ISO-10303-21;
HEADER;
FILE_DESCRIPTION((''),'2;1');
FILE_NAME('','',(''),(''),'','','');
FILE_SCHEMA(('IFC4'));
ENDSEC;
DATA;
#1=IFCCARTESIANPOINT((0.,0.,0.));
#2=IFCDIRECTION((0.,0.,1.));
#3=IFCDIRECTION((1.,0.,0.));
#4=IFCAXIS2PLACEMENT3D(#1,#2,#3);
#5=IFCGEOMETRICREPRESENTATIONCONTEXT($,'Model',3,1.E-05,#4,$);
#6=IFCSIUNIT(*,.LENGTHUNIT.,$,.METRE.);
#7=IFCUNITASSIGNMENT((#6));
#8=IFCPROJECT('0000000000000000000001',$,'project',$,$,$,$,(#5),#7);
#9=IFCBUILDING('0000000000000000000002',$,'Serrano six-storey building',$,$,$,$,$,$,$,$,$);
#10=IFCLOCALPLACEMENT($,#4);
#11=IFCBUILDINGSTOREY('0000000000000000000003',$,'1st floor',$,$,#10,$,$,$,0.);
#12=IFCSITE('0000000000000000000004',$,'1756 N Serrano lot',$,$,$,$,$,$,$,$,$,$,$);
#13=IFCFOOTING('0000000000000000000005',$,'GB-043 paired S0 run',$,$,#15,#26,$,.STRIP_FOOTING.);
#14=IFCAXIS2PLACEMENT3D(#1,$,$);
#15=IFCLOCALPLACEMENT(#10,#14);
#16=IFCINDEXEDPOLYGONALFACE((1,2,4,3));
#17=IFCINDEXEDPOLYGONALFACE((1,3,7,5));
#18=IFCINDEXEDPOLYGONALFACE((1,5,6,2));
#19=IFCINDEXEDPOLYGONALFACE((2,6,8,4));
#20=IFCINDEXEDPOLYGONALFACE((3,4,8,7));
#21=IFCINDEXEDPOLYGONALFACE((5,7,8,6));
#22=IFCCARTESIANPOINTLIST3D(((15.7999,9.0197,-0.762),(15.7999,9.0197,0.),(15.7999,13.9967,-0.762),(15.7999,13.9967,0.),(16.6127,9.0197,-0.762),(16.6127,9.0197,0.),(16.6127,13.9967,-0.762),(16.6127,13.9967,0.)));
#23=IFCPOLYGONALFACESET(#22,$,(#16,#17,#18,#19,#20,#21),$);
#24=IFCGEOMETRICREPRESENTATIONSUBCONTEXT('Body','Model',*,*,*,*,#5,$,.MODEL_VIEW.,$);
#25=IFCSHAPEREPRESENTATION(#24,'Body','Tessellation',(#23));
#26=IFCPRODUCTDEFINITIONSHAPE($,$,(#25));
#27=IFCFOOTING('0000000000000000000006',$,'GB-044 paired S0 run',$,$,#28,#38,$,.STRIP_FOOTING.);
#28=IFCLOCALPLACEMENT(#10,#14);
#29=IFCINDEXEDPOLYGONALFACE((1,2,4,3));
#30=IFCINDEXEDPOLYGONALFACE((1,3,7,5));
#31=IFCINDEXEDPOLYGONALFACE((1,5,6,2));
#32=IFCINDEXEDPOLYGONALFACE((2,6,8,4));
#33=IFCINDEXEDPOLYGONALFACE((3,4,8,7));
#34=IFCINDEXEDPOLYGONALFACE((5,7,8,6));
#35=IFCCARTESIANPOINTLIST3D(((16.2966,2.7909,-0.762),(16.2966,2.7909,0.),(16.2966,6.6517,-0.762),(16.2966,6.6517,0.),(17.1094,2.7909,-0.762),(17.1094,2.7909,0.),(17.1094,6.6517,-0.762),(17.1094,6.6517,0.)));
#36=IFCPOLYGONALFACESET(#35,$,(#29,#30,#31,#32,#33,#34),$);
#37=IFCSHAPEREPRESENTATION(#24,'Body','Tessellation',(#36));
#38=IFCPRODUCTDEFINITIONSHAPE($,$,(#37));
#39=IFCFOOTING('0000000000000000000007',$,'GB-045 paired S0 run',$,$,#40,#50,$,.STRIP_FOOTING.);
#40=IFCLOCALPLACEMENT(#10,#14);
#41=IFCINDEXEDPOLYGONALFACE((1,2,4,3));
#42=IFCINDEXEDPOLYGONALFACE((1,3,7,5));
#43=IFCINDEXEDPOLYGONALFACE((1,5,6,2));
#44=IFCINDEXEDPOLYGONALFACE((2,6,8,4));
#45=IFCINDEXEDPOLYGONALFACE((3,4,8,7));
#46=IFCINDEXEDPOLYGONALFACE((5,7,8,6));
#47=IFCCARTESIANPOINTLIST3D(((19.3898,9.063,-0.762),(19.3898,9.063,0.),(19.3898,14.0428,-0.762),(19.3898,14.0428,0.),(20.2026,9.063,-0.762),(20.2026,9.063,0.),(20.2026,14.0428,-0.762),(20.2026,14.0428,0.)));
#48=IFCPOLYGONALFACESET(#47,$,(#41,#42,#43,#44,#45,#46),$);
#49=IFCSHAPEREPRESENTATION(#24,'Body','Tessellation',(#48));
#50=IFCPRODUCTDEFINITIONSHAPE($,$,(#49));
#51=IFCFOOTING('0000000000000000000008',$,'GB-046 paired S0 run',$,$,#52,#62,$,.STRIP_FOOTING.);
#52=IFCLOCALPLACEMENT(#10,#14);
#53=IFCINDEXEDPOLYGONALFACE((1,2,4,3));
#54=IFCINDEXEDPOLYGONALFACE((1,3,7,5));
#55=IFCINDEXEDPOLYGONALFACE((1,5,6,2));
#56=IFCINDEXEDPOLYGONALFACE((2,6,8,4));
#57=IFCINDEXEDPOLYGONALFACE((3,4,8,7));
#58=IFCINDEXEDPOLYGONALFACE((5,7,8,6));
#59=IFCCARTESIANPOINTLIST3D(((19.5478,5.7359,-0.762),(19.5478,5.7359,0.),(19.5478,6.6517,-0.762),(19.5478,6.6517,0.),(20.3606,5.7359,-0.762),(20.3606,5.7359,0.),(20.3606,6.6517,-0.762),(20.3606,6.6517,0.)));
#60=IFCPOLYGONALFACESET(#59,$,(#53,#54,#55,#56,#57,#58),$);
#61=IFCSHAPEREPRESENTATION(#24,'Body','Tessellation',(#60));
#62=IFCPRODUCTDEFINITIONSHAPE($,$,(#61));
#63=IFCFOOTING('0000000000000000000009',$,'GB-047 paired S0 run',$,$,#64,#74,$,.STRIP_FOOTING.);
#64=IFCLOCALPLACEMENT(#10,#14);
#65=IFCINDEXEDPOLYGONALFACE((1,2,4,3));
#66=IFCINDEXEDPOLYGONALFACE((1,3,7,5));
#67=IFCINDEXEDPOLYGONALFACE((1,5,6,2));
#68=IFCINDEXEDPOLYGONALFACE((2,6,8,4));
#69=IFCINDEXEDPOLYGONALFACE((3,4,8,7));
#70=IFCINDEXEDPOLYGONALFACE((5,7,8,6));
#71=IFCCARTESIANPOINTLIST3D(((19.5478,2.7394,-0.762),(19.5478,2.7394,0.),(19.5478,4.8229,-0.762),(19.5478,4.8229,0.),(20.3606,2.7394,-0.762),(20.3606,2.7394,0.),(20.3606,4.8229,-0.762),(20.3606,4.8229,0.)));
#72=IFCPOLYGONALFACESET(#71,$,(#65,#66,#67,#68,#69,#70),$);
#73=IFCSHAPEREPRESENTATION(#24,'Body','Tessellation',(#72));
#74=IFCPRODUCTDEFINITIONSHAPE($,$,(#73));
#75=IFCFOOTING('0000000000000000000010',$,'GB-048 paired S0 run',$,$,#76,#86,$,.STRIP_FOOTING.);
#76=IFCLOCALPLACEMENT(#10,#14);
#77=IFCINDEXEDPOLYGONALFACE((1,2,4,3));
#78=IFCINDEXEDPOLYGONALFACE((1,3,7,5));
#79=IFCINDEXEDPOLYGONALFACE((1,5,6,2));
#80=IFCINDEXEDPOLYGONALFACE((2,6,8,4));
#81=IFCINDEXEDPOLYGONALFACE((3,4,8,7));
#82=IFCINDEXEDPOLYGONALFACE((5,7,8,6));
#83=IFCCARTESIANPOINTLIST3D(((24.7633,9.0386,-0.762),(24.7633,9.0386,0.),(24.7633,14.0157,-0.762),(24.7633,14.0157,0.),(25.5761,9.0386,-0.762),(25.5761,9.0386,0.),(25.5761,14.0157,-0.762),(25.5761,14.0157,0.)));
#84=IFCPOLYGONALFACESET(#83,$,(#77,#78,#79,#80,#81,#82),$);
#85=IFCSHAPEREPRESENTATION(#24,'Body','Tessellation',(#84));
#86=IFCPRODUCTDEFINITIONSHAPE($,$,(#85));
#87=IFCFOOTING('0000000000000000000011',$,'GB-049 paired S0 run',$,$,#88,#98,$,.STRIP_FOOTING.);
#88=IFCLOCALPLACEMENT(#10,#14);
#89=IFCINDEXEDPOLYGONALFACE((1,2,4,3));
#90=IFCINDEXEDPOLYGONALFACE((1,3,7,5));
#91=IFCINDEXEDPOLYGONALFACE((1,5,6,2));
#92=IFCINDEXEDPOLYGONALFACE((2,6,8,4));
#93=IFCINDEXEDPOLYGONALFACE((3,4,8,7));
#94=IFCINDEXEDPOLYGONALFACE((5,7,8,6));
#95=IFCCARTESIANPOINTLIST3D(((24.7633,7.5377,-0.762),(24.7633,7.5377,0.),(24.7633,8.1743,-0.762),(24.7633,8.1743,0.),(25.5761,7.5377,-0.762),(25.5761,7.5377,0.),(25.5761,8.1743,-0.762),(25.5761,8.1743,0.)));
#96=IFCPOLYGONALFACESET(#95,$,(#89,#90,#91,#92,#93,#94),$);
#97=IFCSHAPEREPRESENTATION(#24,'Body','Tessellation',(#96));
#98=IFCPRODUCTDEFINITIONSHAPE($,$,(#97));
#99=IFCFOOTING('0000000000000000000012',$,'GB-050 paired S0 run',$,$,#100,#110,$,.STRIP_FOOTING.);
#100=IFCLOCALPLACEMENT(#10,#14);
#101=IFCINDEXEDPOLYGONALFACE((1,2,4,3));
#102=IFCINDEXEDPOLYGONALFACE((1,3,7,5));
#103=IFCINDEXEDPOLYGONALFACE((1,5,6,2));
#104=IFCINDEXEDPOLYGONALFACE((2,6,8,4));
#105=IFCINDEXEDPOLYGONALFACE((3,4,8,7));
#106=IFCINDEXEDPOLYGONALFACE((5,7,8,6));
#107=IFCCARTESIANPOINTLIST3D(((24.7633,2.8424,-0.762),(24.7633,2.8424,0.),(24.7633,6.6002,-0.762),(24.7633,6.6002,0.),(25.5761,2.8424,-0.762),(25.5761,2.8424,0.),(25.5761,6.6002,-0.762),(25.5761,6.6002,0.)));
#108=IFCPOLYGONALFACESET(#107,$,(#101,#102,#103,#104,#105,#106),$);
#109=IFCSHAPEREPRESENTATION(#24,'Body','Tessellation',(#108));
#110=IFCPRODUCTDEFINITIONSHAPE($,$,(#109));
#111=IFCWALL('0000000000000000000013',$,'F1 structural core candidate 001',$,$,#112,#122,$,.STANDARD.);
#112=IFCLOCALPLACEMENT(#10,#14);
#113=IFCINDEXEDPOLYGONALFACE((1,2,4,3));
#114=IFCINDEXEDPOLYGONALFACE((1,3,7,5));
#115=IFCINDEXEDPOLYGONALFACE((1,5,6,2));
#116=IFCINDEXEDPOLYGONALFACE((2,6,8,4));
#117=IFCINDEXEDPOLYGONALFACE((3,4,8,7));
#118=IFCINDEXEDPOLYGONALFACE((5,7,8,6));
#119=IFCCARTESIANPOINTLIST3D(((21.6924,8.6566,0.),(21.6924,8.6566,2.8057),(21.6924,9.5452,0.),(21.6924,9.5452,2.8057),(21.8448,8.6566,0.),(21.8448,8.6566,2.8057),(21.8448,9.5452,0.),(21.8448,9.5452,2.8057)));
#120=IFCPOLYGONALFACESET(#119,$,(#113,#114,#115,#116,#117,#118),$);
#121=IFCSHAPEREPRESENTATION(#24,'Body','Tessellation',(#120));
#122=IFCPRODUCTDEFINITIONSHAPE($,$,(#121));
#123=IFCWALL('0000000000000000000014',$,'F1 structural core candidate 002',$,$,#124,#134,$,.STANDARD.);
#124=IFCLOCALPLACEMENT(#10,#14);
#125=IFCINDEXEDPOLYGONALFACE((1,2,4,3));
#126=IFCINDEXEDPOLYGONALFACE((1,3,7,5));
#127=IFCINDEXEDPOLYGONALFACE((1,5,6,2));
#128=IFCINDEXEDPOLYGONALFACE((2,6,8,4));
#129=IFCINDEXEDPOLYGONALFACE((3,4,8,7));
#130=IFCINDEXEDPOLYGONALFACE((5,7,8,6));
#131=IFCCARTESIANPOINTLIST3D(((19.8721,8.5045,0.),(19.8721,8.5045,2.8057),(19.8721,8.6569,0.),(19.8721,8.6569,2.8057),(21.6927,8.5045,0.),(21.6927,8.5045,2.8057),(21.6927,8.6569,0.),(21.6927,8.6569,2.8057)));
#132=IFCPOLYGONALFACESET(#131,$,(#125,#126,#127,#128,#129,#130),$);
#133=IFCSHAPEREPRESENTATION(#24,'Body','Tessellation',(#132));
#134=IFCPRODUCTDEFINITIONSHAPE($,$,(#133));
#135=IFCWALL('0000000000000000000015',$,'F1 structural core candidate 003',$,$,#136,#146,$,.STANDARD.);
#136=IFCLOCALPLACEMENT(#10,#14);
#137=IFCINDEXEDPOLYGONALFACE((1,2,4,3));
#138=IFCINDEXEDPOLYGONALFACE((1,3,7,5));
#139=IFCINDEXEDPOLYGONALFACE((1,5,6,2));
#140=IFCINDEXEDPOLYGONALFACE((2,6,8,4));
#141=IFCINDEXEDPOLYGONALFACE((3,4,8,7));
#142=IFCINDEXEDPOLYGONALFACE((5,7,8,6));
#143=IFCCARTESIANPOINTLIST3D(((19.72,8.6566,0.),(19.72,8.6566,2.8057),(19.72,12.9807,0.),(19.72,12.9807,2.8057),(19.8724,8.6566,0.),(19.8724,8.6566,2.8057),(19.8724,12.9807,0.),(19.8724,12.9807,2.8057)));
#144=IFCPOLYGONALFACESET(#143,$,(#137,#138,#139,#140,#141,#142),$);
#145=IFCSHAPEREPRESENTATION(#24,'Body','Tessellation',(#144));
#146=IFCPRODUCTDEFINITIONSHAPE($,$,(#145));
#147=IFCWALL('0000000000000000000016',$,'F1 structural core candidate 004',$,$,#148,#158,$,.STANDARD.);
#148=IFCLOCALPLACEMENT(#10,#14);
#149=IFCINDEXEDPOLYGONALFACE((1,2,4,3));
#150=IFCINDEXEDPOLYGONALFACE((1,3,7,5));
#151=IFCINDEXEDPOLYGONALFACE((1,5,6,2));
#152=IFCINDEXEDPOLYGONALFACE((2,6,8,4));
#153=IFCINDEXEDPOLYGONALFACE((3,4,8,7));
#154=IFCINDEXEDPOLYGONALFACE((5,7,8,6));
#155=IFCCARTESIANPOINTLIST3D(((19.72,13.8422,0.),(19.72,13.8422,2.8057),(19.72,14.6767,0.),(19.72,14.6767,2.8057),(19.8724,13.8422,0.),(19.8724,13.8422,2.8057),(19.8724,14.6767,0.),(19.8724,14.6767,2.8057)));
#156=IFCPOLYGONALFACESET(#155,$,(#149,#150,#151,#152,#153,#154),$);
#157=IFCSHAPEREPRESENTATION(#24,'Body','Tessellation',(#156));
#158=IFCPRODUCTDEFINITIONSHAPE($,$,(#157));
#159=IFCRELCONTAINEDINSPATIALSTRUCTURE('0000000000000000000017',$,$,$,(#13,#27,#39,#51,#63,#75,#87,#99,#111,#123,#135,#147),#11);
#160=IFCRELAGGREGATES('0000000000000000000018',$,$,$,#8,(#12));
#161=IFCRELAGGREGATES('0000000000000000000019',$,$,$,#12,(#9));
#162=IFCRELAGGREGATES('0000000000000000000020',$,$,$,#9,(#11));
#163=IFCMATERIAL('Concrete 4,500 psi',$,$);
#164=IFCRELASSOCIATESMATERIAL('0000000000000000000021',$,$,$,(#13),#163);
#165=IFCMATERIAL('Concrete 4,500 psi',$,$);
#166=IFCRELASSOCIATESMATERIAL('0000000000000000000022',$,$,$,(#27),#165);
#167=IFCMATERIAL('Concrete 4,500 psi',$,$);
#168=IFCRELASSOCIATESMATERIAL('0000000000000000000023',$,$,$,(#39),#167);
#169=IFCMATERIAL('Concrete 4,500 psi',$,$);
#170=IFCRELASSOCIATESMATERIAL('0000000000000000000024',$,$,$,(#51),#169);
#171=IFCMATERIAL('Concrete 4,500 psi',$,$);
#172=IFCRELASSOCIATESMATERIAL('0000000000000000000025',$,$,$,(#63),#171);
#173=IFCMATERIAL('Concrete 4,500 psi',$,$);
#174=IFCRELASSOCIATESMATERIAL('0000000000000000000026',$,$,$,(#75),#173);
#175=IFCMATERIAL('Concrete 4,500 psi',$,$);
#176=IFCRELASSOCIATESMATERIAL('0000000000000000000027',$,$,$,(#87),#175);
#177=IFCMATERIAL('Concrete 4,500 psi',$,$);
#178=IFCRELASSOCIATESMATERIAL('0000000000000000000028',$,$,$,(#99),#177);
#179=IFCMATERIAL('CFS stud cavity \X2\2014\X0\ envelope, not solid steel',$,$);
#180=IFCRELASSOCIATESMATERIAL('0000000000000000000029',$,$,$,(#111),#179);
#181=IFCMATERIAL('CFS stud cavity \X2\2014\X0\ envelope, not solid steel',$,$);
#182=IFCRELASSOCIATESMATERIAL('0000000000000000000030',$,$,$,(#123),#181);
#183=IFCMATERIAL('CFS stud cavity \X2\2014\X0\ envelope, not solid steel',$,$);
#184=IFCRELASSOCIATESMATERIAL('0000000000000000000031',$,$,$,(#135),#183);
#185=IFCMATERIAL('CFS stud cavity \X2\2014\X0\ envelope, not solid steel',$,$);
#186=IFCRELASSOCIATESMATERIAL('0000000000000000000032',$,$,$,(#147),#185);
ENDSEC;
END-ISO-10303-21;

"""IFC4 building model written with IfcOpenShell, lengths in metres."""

from ifc_helpers import new_model, si_unit, frame, origin, origin_with_axes, place, context, subcontext, project, spatial, polyline, outline, extrude, material, element, save


model = new_model("IFC4")

# Units and contexts
model_context = context("Model", 3, precision=1e-05, world=origin_with_axes())
body_context = subcontext(model_context, "Body", "Model", "MODEL_VIEW")
ifc_project = project(units=[si_unit("LENGTHUNIT", "METRE")], contexts=[model_context])

# Site, building, storey
site = spatial("IfcSite", under=ifc_project, Name="1756 N Serrano lot")
building = spatial("IfcBuilding", under=site, Name="Serrano six-storey building")
storey_placement = place(None, origin_with_axes())
storey = spatial("IfcBuildingStorey", under=building, at=storey_placement, Name="1st floor", Elevation=0.0)

# Footings
ifc_material_1 = material(Name="Concrete 4,500 psi")
footing_1_placement = place(storey_placement, origin_with_axes())
element("IfcFooting", 1, at=footing_1_placement, inside=storey, material=ifc_material_1, Name="GB-043 paired S0 run", PredefinedType="STRIP_FOOTING", context=body_context, shape_type="SweptSolid", body=[
    extrude(outline(polyline([(16.6127, 9.0197), (15.7999, 9.0197), (15.7999, 13.9967), (16.6127, 13.9967), (16.6127, 9.0197)])), frame((0.0, 0.0, -0.762)), (0.0, 0.0, 1.0), 0.762),
])
ifc_material_2 = material(Name="Concrete 4,500 psi")
footing_2_placement = place(storey_placement, origin_with_axes())
element("IfcFooting", 2, at=footing_2_placement, inside=storey, material=ifc_material_2, Name="GB-044 paired S0 run", PredefinedType="STRIP_FOOTING", context=body_context, shape_type="SweptSolid", body=[
    extrude(outline(polyline([(17.1094, 2.7909), (16.2966, 2.7909), (16.2966, 6.6517), (17.1094, 6.6517), (17.1094, 2.7909)])), frame((0.0, 0.0, -0.762)), (0.0, 0.0, 1.0), 0.762),
])
ifc_material_3 = material(Name="Concrete 4,500 psi")
footing_3_placement = place(storey_placement, origin_with_axes())
element("IfcFooting", 3, at=footing_3_placement, inside=storey, material=ifc_material_3, Name="GB-045 paired S0 run", PredefinedType="STRIP_FOOTING", context=body_context, shape_type="SweptSolid", body=[
    extrude(outline(polyline([(20.2026, 9.063), (19.3898, 9.063), (19.3898, 14.0428), (20.2026, 14.0428), (20.2026, 9.063)])), frame((0.0, 0.0, -0.762)), (0.0, 0.0, 1.0), 0.762),
])
ifc_material_4 = material(Name="Concrete 4,500 psi")
footing_4_placement = place(storey_placement, origin_with_axes())
element("IfcFooting", 4, at=footing_4_placement, inside=storey, material=ifc_material_4, Name="GB-046 paired S0 run", PredefinedType="STRIP_FOOTING", context=body_context, shape_type="SweptSolid", body=[
    extrude(outline(polyline([(20.3606, 5.7359), (19.5478, 5.7359), (19.5478, 6.6517), (20.3606, 6.6517), (20.3606, 5.7359)])), frame((0.0, 0.0, -0.762)), (0.0, 0.0, 1.0), 0.762),
])
ifc_material_5 = material(Name="Concrete 4,500 psi")
footing_5_placement = place(storey_placement, origin_with_axes())
element("IfcFooting", 5, at=footing_5_placement, inside=storey, material=ifc_material_5, Name="GB-047 paired S0 run", PredefinedType="STRIP_FOOTING", context=body_context, shape_type="SweptSolid", body=[
    extrude(outline(polyline([(20.3606, 2.7394), (19.5478, 2.7394), (19.5478, 4.8229), (20.3606, 4.8229), (20.3606, 2.7394)])), frame((0.0, 0.0, -0.762)), (0.0, 0.0, 1.0), 0.762),
])
ifc_material_6 = material(Name="Concrete 4,500 psi")
footing_6_placement = place(storey_placement, origin_with_axes())
element("IfcFooting", 6, at=footing_6_placement, inside=storey, material=ifc_material_6, Name="GB-048 paired S0 run", PredefinedType="STRIP_FOOTING", context=body_context, shape_type="SweptSolid", body=[
    extrude(outline(polyline([(25.5761, 9.0386), (24.7633, 9.0386), (24.7633, 14.0157), (25.5761, 14.0157), (25.5761, 9.0386)])), frame((0.0, 0.0, -0.762)), (0.0, 0.0, 1.0), 0.762),
])
ifc_material_7 = material(Name="Concrete 4,500 psi")
footing_7_placement = place(storey_placement, origin_with_axes())
element("IfcFooting", 7, at=footing_7_placement, inside=storey, material=ifc_material_7, Name="GB-049 paired S0 run", PredefinedType="STRIP_FOOTING", context=body_context, shape_type="SweptSolid", body=[
    extrude(outline(polyline([(25.5761, 7.5377), (24.7633, 7.5377), (24.7633, 8.1743), (25.5761, 8.1743), (25.5761, 7.5377)])), frame((0.0, 0.0, -0.762)), (0.0, 0.0, 1.0), 0.762),
])
ifc_material_8 = material(Name="Concrete 4,500 psi")
footing_8_placement = place(storey_placement, origin_with_axes())
element("IfcFooting", 8, at=footing_8_placement, inside=storey, material=ifc_material_8, Name="GB-050 paired S0 run", PredefinedType="STRIP_FOOTING", context=body_context, shape_type="SweptSolid", body=[
    extrude(outline(polyline([(25.5761, 2.8424), (24.7633, 2.8424), (24.7633, 6.6002), (25.5761, 6.6002), (25.5761, 2.8424)])), frame((0.0, 0.0, -0.762)), (0.0, 0.0, 1.0), 0.762),
])

# Walls
ifc_material_9 = material(Name="CFS stud cavity — envelope, not solid steel")
wall_1_placement = place(storey_placement, origin_with_axes())
element("IfcWall", 9, at=wall_1_placement, inside=storey, material=ifc_material_9, Name="F1 structural core candidate 001", PredefinedType="STANDARD", context=body_context, shape_type="SweptSolid", body=[
    extrude(outline(polyline([(21.8448, 8.6566), (21.6924, 8.6566), (21.6924, 9.5452), (21.8448, 9.5452), (21.8448, 8.6566)])), origin(), (0.0, 0.0, 1.0), 2.8057),
])
ifc_material_10 = material(Name="CFS stud cavity — envelope, not solid steel")
wall_2_placement = place(storey_placement, origin_with_axes())
element("IfcWall", 10, at=wall_2_placement, inside=storey, material=ifc_material_10, Name="F1 structural core candidate 002", PredefinedType="STANDARD", context=body_context, shape_type="SweptSolid", body=[
    extrude(outline(polyline([(21.6927, 8.6569), (21.6927, 8.5045), (19.8721, 8.5045), (19.8721, 8.6569), (21.6927, 8.6569)])), origin(), (0.0, 0.0, 1.0), 2.8057),
])
ifc_material_11 = material(Name="CFS stud cavity — envelope, not solid steel")
wall_3_placement = place(storey_placement, origin_with_axes())
element("IfcWall", 11, at=wall_3_placement, inside=storey, material=ifc_material_11, Name="F1 structural core candidate 003", PredefinedType="STANDARD", context=body_context, shape_type="SweptSolid", body=[
    extrude(outline(polyline([(19.8724, 8.6566), (19.72, 8.6566), (19.72, 12.9807), (19.8724, 12.9807), (19.8724, 8.6566)])), origin(), (0.0, 0.0, 1.0), 2.8057),
])
ifc_material_12 = material(Name="CFS stud cavity — envelope, not solid steel")
wall_4_placement = place(storey_placement, origin_with_axes())
element("IfcWall", 12, at=wall_4_placement, inside=storey, material=ifc_material_12, Name="F1 structural core candidate 004", PredefinedType="STANDARD", context=body_context, shape_type="SweptSolid", body=[
    extrude(outline(polyline([(19.8724, 13.8422), (19.72, 13.8422), (19.72, 14.6767), (19.8724, 14.6767), (19.8724, 13.8422)])), origin(), (0.0, 0.0, 1.0), 2.8057),
])

save(model, "model.ifc")
